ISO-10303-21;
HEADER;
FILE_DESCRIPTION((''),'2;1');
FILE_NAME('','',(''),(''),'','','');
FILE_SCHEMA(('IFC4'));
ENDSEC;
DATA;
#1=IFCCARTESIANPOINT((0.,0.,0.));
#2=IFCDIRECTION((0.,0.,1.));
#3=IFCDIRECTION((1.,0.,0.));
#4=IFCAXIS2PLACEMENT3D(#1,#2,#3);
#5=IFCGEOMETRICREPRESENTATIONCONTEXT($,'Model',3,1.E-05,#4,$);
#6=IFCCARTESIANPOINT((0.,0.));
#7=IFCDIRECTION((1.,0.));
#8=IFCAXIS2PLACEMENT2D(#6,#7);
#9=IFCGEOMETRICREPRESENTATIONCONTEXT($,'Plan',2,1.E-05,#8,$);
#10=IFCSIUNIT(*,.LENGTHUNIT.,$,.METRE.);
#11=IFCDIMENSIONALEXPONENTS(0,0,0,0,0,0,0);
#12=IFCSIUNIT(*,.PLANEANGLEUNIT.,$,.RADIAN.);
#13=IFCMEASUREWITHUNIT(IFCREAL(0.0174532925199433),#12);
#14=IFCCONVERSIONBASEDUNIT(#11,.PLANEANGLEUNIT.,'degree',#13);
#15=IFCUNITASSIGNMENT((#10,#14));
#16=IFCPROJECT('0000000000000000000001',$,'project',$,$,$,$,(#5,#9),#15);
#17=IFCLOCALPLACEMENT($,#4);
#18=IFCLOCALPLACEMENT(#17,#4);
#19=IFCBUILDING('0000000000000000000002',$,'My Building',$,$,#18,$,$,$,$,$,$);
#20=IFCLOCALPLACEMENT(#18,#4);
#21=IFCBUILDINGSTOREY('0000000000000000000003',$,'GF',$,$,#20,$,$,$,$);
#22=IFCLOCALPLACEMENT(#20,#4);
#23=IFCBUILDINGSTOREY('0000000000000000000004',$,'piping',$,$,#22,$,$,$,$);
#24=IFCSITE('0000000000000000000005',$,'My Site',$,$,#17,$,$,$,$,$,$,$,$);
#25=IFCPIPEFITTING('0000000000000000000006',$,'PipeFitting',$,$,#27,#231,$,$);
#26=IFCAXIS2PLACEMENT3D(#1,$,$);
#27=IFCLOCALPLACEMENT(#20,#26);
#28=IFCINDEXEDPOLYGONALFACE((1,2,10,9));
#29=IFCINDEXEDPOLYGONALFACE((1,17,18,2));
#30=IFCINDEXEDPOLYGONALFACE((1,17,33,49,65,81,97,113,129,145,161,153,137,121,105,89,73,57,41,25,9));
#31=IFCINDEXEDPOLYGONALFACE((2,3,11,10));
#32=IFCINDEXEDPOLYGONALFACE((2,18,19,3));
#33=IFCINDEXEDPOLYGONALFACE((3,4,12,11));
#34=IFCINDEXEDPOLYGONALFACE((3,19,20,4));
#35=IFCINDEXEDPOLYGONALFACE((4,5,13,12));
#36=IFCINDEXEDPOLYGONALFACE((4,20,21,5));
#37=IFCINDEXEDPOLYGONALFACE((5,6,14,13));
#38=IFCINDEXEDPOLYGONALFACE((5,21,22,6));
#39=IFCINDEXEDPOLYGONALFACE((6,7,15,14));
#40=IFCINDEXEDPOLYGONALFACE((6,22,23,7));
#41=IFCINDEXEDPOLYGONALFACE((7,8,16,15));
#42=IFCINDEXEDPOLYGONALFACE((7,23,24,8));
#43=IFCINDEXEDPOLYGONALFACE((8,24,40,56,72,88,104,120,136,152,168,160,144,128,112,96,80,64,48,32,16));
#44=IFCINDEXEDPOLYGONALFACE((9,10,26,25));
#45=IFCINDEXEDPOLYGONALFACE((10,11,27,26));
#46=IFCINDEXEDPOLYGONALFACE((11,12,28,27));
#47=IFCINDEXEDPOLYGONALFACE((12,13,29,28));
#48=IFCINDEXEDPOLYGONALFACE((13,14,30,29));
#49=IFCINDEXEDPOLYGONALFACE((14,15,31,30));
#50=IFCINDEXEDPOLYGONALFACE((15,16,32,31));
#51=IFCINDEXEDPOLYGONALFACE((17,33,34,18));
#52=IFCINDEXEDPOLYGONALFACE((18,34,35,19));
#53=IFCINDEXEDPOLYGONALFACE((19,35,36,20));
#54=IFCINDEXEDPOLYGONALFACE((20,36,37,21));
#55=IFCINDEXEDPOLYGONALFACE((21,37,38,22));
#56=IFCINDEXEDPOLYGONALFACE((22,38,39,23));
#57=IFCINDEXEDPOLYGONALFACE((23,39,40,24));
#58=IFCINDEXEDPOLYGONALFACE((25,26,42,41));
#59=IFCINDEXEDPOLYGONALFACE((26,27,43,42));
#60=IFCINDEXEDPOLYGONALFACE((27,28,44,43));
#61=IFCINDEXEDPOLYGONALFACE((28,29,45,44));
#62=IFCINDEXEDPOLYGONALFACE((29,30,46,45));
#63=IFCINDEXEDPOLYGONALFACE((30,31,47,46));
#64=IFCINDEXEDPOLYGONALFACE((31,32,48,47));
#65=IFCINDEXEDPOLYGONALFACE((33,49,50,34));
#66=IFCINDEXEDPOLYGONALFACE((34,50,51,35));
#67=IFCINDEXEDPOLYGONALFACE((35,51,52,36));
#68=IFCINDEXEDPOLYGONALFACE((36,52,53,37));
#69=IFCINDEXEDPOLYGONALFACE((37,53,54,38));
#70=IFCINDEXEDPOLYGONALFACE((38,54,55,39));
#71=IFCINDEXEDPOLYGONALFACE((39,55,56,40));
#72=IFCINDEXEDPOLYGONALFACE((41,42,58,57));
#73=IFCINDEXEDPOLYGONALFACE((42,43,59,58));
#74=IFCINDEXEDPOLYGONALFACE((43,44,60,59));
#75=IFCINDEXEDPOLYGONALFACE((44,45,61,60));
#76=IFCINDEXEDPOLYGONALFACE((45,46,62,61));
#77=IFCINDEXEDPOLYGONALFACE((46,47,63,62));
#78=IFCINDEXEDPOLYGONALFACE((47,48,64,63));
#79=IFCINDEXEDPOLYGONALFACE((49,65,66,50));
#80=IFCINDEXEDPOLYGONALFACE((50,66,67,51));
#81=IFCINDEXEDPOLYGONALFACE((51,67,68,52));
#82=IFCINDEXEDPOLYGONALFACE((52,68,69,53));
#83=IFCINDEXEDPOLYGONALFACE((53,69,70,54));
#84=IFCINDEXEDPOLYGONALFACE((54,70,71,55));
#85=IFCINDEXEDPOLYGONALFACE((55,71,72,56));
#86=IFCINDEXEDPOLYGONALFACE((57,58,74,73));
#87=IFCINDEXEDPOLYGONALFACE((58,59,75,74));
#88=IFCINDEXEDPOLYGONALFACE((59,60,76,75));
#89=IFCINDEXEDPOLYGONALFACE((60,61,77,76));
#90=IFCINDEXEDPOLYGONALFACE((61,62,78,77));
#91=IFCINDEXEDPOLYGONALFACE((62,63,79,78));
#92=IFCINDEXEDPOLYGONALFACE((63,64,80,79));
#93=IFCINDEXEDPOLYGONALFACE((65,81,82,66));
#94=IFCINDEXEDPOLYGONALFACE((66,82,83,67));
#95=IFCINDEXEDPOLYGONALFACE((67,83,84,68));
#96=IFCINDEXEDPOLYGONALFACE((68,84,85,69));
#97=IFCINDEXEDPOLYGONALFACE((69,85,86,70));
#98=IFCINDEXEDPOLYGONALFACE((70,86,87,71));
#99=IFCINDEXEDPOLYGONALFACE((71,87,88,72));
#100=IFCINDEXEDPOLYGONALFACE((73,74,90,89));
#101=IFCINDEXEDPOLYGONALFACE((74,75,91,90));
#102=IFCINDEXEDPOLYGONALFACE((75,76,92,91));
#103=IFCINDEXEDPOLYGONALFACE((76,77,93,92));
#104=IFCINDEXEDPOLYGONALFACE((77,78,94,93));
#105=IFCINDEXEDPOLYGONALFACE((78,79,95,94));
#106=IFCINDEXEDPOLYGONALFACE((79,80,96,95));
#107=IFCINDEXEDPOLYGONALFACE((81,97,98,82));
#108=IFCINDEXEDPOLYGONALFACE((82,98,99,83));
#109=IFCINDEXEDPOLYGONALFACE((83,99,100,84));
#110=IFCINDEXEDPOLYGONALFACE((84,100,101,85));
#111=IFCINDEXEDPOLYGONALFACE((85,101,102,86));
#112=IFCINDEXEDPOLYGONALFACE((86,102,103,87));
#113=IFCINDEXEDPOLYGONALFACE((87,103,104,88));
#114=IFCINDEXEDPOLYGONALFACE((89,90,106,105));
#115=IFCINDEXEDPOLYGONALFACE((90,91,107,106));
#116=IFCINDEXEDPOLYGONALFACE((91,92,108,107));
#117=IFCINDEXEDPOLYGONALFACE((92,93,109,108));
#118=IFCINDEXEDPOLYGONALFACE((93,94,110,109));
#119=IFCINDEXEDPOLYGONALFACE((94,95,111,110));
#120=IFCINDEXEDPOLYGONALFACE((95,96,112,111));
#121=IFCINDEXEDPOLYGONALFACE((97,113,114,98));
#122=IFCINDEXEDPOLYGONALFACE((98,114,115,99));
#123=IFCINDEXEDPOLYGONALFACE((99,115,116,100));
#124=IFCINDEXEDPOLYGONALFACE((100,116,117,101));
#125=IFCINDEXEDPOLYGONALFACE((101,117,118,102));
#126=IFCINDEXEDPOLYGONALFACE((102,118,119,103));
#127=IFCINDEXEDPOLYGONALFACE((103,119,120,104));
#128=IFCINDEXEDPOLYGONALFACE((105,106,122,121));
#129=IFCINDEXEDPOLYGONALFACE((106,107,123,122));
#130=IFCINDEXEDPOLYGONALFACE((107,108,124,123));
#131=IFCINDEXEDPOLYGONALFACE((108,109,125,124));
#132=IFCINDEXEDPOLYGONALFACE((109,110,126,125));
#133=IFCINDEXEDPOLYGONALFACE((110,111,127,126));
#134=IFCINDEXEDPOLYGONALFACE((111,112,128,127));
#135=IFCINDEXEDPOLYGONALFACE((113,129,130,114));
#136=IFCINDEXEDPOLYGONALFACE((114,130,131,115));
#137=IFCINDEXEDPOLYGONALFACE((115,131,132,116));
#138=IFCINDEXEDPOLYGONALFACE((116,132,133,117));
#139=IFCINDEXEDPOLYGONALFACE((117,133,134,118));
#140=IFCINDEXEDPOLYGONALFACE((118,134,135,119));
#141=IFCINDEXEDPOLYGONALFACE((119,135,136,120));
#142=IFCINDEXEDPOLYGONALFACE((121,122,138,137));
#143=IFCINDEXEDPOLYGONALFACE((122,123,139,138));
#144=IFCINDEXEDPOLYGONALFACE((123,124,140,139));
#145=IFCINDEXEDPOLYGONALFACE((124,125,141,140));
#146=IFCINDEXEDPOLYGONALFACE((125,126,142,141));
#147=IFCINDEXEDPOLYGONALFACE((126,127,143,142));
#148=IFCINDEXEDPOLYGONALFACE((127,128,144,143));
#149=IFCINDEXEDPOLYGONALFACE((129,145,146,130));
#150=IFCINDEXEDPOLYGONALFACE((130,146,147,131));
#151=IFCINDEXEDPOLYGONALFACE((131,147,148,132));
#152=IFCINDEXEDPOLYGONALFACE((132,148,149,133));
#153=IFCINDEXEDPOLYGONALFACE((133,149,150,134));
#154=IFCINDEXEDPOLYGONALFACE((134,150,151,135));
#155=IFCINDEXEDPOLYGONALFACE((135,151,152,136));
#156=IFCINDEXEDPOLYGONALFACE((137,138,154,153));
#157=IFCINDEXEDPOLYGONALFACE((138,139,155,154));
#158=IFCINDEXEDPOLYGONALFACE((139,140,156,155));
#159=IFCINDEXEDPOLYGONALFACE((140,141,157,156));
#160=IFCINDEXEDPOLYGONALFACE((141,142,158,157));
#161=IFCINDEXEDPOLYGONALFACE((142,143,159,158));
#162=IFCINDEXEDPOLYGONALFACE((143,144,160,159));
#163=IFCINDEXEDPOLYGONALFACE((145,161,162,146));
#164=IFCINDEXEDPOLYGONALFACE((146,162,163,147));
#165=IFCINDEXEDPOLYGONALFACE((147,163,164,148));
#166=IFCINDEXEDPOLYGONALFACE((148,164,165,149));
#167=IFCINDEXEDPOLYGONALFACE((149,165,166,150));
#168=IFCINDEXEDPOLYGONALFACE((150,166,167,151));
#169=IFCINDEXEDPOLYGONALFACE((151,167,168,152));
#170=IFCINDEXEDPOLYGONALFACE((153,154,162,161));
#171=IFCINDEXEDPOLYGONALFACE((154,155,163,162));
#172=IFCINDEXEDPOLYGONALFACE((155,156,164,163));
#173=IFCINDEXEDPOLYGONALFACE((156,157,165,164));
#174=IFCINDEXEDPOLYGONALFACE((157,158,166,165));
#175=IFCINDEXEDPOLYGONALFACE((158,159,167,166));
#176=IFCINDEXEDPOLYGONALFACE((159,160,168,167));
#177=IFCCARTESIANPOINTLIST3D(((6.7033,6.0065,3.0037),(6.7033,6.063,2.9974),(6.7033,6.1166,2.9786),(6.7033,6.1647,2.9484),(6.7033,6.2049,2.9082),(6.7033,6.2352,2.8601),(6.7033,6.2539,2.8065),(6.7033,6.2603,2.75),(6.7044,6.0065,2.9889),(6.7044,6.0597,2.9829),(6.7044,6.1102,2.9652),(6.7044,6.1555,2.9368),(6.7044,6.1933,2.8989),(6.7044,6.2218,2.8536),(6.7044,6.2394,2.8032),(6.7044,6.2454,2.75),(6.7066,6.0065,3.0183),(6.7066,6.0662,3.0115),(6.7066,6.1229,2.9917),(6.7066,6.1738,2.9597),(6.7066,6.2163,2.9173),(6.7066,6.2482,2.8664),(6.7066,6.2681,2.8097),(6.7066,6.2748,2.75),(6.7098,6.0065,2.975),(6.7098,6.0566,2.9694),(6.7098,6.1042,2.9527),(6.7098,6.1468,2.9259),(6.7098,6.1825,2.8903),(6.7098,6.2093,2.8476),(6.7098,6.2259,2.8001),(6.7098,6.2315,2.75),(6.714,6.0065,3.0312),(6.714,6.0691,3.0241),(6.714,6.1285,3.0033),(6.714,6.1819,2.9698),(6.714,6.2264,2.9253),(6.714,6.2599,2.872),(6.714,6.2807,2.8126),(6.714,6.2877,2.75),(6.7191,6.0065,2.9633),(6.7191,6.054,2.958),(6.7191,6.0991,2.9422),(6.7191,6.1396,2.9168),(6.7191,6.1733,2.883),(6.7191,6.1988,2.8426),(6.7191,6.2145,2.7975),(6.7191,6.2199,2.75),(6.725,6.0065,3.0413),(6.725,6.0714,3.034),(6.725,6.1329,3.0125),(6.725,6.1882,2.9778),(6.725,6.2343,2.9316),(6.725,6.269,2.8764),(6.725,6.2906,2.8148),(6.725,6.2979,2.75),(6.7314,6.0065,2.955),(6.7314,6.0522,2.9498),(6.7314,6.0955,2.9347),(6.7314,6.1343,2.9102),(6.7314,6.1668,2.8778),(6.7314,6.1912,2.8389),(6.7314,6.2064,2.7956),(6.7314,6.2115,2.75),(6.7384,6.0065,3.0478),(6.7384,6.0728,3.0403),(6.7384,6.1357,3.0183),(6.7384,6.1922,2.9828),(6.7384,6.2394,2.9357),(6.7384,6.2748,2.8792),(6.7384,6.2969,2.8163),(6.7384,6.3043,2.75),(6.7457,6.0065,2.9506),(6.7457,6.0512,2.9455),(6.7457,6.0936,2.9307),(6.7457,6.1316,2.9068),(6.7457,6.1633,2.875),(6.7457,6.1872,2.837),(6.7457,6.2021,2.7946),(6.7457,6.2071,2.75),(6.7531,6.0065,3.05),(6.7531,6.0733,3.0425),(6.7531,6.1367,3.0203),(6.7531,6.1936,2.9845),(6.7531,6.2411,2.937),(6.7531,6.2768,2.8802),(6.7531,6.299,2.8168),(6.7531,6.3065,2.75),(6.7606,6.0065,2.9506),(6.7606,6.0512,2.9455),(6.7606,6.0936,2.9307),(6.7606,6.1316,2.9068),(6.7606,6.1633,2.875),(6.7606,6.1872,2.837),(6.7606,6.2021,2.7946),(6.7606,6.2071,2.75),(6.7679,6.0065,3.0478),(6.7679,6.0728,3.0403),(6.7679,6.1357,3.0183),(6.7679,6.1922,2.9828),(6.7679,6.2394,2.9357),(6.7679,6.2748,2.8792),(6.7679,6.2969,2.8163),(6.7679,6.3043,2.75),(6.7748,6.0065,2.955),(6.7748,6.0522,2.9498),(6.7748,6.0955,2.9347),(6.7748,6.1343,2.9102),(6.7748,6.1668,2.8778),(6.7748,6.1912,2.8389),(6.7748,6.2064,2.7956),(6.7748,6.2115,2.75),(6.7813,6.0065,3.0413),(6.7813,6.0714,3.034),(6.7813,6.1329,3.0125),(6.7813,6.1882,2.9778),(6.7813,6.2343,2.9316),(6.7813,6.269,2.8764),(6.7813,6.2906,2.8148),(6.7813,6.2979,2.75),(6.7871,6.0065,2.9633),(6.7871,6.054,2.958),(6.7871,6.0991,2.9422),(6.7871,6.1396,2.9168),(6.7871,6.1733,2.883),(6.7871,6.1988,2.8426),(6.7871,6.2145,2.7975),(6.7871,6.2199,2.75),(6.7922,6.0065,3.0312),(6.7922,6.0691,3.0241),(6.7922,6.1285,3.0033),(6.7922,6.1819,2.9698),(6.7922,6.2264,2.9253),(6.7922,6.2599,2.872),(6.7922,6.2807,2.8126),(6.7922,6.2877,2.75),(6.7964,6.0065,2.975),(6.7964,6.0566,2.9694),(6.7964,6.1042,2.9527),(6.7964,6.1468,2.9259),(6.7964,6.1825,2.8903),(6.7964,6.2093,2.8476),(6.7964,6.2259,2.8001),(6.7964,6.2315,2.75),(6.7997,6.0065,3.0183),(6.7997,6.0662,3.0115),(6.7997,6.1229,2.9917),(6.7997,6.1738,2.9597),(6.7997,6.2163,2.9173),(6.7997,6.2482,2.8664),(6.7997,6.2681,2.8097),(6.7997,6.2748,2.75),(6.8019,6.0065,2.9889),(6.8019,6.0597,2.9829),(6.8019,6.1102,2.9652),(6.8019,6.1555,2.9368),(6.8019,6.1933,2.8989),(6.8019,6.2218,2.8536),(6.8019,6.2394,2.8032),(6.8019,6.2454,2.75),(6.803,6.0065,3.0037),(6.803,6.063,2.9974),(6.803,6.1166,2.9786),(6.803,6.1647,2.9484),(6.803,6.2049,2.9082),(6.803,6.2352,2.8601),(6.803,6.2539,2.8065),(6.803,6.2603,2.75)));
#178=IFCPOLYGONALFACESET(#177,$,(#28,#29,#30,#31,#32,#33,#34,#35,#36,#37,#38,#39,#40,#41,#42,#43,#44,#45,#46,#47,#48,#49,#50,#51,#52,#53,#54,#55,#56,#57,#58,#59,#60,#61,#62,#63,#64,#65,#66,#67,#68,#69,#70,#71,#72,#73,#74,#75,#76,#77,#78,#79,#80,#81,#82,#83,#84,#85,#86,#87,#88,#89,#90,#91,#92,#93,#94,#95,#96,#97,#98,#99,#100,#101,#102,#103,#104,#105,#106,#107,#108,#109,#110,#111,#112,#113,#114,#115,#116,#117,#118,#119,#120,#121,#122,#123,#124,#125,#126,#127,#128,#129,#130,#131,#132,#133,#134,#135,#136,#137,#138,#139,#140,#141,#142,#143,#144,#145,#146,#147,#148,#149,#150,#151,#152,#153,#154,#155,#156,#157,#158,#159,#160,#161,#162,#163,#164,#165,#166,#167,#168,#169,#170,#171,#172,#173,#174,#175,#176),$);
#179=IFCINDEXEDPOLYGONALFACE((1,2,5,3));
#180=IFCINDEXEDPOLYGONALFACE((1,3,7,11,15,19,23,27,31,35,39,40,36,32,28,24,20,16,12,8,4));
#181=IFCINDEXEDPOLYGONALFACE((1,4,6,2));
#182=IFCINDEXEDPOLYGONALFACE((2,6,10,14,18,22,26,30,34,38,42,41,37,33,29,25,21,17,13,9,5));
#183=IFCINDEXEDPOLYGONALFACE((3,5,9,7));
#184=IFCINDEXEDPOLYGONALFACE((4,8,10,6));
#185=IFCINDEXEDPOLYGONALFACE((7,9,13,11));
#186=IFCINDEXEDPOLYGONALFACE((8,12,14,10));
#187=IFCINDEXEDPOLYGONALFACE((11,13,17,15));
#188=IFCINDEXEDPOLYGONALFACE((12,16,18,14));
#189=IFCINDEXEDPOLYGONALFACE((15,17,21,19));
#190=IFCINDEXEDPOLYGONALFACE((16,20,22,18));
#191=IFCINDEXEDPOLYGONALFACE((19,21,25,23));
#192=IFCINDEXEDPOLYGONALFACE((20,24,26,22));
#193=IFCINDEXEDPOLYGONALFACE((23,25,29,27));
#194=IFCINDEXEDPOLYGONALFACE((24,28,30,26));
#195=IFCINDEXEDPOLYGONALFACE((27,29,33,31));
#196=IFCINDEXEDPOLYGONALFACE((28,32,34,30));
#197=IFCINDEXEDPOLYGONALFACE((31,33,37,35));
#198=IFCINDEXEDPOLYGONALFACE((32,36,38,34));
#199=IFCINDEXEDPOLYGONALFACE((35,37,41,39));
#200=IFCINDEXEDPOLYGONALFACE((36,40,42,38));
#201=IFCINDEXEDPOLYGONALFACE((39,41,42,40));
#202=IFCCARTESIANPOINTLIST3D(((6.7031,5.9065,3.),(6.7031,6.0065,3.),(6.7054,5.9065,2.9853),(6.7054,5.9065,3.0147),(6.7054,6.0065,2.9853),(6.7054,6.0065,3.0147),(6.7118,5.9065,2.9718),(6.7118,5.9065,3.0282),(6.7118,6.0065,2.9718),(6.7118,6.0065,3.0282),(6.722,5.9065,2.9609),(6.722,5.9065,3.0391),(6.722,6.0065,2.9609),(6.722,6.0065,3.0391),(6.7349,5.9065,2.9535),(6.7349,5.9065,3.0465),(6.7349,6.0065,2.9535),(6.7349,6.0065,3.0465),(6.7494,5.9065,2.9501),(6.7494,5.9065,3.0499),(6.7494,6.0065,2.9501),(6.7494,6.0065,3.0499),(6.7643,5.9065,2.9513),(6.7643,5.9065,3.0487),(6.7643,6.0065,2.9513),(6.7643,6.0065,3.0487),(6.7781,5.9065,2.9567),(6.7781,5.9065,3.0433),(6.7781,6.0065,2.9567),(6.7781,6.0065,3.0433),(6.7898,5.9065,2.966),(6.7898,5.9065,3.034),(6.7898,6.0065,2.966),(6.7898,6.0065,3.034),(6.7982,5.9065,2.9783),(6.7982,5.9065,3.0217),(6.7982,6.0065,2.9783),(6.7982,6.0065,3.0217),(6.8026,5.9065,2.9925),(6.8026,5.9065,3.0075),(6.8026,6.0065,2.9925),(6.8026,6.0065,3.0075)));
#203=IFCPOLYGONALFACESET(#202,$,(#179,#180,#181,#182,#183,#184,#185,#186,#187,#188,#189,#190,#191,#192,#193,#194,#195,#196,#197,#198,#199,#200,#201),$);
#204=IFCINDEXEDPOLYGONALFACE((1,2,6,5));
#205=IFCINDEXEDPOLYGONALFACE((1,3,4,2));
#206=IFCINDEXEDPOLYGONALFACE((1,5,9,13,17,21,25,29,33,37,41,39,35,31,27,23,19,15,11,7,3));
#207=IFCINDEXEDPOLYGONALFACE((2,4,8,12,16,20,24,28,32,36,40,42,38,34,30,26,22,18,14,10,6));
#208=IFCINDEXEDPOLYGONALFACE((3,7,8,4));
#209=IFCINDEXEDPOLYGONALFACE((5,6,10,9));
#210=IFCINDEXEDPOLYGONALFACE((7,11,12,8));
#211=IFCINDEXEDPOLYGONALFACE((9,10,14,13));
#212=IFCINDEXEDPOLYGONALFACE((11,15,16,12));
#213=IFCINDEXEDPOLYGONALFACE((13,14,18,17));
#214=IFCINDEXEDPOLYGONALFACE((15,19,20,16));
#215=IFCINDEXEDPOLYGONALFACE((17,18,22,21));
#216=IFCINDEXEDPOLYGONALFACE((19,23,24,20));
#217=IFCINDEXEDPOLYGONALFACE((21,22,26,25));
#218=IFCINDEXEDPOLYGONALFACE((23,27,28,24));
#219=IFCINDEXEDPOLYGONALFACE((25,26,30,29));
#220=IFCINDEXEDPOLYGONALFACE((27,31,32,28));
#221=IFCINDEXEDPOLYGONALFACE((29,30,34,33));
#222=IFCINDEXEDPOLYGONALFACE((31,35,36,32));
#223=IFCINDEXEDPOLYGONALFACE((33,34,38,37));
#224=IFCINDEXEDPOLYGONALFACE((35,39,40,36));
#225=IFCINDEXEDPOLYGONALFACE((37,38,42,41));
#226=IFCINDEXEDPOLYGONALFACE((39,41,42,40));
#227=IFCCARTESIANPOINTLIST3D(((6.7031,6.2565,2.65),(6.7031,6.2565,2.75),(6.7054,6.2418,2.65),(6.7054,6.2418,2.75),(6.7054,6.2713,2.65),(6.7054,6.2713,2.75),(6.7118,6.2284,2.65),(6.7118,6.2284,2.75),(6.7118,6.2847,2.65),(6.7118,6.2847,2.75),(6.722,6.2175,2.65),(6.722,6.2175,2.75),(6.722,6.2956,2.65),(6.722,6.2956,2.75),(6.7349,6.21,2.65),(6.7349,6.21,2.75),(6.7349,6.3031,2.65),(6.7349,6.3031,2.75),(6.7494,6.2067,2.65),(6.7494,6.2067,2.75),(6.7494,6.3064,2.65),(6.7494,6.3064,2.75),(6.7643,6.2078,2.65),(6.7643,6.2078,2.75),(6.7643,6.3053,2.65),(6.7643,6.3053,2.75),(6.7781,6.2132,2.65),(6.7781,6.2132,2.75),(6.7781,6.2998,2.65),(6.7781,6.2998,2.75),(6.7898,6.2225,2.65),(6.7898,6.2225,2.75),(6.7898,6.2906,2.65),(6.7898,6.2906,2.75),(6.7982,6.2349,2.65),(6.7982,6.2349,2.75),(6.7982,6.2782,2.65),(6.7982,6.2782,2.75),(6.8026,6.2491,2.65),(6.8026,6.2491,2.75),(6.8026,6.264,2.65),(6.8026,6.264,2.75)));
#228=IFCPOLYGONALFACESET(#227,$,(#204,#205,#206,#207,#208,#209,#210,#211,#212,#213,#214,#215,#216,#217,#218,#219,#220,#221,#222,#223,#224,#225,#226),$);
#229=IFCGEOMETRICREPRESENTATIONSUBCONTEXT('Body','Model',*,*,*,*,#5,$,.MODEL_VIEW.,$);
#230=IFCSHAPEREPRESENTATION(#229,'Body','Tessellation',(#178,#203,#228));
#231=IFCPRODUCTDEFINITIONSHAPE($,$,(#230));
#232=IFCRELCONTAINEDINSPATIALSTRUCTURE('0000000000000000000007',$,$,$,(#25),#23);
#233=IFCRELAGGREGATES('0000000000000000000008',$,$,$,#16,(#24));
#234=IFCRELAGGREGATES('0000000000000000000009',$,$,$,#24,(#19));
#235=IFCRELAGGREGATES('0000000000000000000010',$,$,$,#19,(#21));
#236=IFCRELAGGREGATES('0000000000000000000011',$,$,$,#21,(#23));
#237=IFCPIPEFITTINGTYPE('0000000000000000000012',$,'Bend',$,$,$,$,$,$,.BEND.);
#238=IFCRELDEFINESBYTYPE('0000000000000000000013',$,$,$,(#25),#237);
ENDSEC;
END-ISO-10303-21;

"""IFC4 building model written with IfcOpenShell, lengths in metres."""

from ifc_helpers import new_model, entity, si_unit, converted_unit, frame, origin_with_axes, origin_2d_with_axis, place, context, subcontext, project, spatial, circle, extrude, source, transform, mapped, type_object, type_shapes, element, save


model = new_model("IFC4")

# Units and contexts
model_context = context("Model", 3, precision=1e-05, world=origin_with_axes())
plan_context = context("Plan", 2, precision=1e-05, world=origin_2d_with_axis())
body_context = subcontext(model_context, "Body", "Model", "MODEL_VIEW")
ifc_project = project(units=[si_unit("LENGTHUNIT", "METRE"), converted_unit("PLANEANGLEUNIT", "degree", entity("IfcReal", 0.0174532925199433), si_unit("PLANEANGLEUNIT", "RADIAN"), dimensions=[0, 0, 0, 0, 0, 0, 0])], contexts=[model_context, plan_context])

# Site, building, storeys
site_placement = place(None, origin_with_axes())
site = spatial("IfcSite", under=ifc_project, at=site_placement, Name="My Site")
building_placement = place(site_placement, origin_with_axes())
building = spatial("IfcBuilding", under=site, at=building_placement, Name="My Building")
storey_1_placement = place(building_placement, origin_with_axes())
storey_1 = spatial("IfcBuildingStorey", under=building, at=storey_1_placement, Name="GF")
storey_2_placement = place(storey_1_placement, origin_with_axes())
storey_2 = spatial("IfcBuildingStorey", under=storey_1, at=storey_2_placement, Name="piping")

# Pipe fitting
pipe_fitting_type = type_object("IfcPipeFittingType", Name="Bend", PredefinedType="BEND")
shared_shape = source(origin_with_axes(), body_context, "Body", "SolidModel", [
    entity("IfcSweptDiskSolid", entity("IfcIndexedPolyCurve", entity("IfcCartesianPointList3D", [[0.0, 0.0, 0.1], [0.0, -0.0732, 0.2768], [0.0, -0.25, 0.35]]), [entity("IfcArcIndex", [1, 2, 3])]), 0.05),
    extrude(circle(Radius=0.05), origin_with_axes(), (0.0, 0.0, 1.0), 0.1),
    extrude(circle(Radius=0.05), frame((0.0, -0.25, 0.35), z_axis=(0.0, -1.0, 0.0), x_axis=(1.0, 0.0, 0.0)), (0.0, 0.0, 1.0), 0.1),
])
type_shapes(pipe_fitting_type, [shared_shape])
for number, where, z_axis, x_axis, name in (
    (1, (6.7531, 5.9065, 3.0), (0.0, 1.0, 0.0), (-1.0, 0.0, 0.0), "PipeFitting"),
):
    element("IfcPipeFitting", number, at=place(storey_2_placement, frame(where, z_axis=z_axis, x_axis=x_axis)), inside=storey_2, type_object=pipe_fitting_type, Name=name, context=body_context, shape_type="MappedRepresentation", body=[
        mapped(shared_shape, transform((0.0, 0.0, 0.0), x_axis=(1.0, 0.0, 0.0), y_axis=(0.0, 1.0, 0.0), z_axis=(0.0, 0.0, 1.0), scale=1.0)),
    ])

save(model, "model.ifc")
